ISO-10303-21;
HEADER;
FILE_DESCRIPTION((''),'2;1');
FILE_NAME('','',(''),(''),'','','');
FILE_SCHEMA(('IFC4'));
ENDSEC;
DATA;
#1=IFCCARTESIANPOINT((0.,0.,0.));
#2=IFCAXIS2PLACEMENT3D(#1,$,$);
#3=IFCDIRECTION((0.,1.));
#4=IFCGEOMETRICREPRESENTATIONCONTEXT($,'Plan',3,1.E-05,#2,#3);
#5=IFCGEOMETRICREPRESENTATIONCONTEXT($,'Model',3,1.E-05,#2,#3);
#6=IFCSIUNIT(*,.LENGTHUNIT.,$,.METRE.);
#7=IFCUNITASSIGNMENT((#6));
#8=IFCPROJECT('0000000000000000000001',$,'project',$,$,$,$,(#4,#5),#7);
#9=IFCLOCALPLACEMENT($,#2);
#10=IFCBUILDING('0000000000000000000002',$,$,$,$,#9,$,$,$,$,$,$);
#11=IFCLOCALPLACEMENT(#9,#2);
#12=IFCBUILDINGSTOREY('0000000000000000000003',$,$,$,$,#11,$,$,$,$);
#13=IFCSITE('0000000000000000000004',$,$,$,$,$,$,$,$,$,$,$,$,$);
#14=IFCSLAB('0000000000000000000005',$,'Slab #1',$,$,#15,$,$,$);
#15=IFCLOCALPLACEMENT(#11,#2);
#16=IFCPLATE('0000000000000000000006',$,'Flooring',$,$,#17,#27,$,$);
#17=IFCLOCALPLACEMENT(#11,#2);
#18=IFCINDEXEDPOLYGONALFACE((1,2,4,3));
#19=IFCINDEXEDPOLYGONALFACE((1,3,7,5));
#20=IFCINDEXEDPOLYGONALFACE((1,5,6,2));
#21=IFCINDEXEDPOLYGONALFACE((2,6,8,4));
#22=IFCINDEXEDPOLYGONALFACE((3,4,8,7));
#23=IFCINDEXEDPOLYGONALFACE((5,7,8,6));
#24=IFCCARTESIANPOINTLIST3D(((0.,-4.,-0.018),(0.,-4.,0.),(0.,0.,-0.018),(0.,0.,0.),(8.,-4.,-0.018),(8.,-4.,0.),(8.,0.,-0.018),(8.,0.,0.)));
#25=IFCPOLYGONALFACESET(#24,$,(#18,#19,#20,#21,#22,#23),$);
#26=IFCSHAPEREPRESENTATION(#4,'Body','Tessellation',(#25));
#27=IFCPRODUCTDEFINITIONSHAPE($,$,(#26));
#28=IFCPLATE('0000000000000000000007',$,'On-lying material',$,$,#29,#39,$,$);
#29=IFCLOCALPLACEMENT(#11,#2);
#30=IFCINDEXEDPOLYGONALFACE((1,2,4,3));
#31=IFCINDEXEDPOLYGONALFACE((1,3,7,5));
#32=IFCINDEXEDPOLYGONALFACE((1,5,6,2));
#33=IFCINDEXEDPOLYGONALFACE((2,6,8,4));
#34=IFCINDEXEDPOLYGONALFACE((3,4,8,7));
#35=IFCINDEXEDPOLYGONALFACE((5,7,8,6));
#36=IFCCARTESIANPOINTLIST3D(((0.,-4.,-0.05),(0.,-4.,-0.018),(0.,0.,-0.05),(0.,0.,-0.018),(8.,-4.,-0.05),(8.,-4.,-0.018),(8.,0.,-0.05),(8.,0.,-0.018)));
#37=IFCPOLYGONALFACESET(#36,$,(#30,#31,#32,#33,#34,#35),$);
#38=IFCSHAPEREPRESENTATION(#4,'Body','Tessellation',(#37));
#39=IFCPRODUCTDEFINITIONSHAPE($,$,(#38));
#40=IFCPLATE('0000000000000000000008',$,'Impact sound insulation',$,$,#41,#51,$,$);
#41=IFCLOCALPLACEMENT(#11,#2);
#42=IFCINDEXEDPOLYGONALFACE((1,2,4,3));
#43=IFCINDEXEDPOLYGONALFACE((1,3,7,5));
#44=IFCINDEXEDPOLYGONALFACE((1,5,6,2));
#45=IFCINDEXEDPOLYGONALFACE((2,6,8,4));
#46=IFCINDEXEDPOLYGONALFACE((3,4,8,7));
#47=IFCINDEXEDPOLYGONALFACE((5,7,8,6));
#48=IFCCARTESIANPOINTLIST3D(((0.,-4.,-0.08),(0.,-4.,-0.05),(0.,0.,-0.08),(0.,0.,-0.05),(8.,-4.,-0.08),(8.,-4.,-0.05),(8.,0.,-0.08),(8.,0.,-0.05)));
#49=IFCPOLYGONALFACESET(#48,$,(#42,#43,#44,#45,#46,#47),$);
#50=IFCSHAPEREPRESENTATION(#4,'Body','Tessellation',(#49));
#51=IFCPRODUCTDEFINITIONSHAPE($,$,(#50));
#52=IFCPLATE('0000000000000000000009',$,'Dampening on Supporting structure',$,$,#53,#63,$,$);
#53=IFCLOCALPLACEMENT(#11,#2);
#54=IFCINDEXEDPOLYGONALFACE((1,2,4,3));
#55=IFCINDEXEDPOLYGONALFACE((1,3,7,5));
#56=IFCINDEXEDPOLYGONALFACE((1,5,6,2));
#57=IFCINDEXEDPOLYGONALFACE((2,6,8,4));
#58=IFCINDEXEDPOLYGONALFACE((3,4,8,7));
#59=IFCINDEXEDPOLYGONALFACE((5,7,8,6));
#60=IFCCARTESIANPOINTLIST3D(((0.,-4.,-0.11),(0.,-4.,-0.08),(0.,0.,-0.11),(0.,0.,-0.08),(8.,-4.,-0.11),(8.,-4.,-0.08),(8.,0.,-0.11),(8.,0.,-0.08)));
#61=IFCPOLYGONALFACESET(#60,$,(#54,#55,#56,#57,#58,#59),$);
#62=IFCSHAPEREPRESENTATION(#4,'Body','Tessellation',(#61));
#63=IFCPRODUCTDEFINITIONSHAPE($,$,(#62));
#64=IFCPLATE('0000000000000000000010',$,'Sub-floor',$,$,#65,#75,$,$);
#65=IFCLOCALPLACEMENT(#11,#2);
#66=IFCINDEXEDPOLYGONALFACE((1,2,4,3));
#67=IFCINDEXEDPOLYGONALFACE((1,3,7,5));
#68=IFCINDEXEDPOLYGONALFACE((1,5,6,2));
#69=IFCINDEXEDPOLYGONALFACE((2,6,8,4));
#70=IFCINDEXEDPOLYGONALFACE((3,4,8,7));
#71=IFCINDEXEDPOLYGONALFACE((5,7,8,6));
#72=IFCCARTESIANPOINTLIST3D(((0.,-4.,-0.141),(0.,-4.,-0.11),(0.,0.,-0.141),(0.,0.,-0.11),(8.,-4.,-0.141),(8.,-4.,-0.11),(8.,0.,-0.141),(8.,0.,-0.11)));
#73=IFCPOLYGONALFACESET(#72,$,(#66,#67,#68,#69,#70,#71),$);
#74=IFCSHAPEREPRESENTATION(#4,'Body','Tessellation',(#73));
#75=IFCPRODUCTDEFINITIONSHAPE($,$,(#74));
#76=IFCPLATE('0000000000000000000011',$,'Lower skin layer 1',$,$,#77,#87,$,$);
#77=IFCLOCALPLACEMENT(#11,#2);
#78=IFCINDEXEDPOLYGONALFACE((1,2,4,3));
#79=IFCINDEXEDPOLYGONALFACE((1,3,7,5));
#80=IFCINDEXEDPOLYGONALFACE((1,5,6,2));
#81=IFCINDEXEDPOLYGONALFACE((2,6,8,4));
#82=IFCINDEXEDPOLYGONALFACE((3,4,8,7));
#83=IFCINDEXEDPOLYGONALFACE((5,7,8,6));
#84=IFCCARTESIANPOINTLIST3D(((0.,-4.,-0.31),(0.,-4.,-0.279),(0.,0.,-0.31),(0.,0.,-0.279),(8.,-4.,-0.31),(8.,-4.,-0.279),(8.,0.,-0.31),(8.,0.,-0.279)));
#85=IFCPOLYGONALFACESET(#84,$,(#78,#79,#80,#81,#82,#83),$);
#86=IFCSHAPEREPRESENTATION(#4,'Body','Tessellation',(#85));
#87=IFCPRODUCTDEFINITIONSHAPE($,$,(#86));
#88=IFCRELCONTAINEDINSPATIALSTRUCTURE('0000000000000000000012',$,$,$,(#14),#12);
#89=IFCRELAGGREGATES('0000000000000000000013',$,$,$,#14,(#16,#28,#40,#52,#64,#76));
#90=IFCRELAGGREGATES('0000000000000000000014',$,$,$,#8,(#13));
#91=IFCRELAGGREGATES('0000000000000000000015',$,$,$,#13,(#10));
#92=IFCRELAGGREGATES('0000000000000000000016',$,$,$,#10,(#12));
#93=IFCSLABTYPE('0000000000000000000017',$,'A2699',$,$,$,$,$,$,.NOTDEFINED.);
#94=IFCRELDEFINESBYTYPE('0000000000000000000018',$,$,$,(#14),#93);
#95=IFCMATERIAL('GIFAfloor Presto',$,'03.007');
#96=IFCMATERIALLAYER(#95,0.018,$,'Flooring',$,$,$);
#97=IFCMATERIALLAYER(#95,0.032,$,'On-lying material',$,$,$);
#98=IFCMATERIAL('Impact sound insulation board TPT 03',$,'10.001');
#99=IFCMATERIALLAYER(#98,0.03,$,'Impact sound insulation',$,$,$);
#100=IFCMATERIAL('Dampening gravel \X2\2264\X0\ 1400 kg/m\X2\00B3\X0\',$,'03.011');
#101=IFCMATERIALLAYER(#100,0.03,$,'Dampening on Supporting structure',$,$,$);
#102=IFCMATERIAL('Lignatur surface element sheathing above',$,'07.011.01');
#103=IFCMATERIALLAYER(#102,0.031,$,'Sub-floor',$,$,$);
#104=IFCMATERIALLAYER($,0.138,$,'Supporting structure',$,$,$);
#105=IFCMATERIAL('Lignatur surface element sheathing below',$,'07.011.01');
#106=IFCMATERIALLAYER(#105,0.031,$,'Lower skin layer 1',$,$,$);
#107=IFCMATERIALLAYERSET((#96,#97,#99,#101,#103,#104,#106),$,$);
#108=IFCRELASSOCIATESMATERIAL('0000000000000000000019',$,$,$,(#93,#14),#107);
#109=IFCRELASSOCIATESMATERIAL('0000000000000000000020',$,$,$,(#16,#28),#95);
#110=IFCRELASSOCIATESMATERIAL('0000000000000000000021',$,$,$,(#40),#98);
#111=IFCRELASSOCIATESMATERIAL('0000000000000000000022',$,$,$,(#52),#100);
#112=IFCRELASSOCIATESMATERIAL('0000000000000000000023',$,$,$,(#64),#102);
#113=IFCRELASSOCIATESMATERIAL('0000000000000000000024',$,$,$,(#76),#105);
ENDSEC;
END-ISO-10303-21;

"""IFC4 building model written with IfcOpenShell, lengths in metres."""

from ifc_helpers import new_model, si_unit, direction, frame, frame_2d, origin, origin_with_axes, place, context, project, spatial, rectangle, extrude, material, layer, layer_set, type_object, element, aggregate, save


model = new_model("IFC4")

# Units and contexts
plan_context = context("Plan", 3, precision=1e-05, world=origin(), true_north=direction((0.0, 1.0)))
model_context = context("Model", 3, precision=1e-05, world=origin(), true_north=direction((0.0, 1.0)))
ifc_project = project(units=[si_unit("LENGTHUNIT", "METRE")], contexts=[plan_context, model_context])

# Site, building, storey
site = spatial("IfcSite", under=ifc_project)
building_placement = place(None, origin())
building = spatial("IfcBuilding", under=site, at=building_placement)
storey_placement = place(building_placement, origin())
storey = spatial("IfcBuildingStorey", under=building, at=storey_placement)

# Slab, plates
ifc_material_1 = material(Name="GIFAfloor Presto", Category="03.007")
ifc_layer_1 = layer(ifc_material_1, 0.018, Name="Flooring")
ifc_layer_2 = layer(ifc_material_1, 0.032, Name="On-lying material")
ifc_material_2 = material(Name="Impact sound insulation board TPT 03", Category="10.001")
ifc_layer_3 = layer(ifc_material_2, 0.03, Name="Impact sound insulation")
ifc_material_3 = material(Name="Dampening gravel ≤ 1400 kg/m³", Category="03.011")
ifc_layer_4 = layer(ifc_material_3, 0.03, Name="Dampening on Supporting structure")
ifc_material_4 = material(Name="Lignatur surface element sheathing above", Category="07.011.01")
ifc_layer_5 = layer(ifc_material_4, 0.031, Name="Sub-floor")
ifc_layer_6 = layer(None, 0.138, Name="Supporting structure")
ifc_material_5 = material(Name="Lignatur surface element sheathing below", Category="07.011.01")
ifc_layer_7 = layer(ifc_material_5, 0.031, Name="Lower skin layer 1")
ifc_layer_set = layer_set([ifc_layer_1, ifc_layer_2, ifc_layer_3, ifc_layer_4, ifc_layer_5, ifc_layer_6, ifc_layer_7])
slab_type = type_object("IfcSlabType", Name="A2699", PredefinedType="NOTDEFINED", material=ifc_layer_set)
slab_placement = place(None, frame((0.0, 0.0, 0.0), z_axis=(0.0, 0.0, -1.0), x_axis=(1.0, 0.0, 0.0)))
slab = element("IfcSlab", 1, at=slab_placement, inside=storey, type_object=slab_type, material=ifc_layer_set, Name="Slab #1")
plate_1_placement = place(slab_placement, origin())
plate_1 = element("IfcPlate", 2, at=plate_1_placement, material=ifc_material_1, Name="Flooring", context=plan_context, shape_type="SweptSolid", body=[
    extrude(rectangle(XDim=8.0, YDim=4.0, at=frame_2d((4.0, 2.0), x_axis=(1.0, 0.0))), origin_with_axes(), (0.0, 0.0, 1.0), 0.018),
])
plate_2_placement = place(slab_placement, origin())
plate_2 = element("IfcPlate", 3, at=plate_2_placement, material=ifc_material_1, Name="On-lying material", context=plan_context, shape_type="SweptSolid", body=[
    extrude(rectangle(XDim=8.0, YDim=4.0, at=frame_2d((4.0, 2.0), x_axis=(1.0, 0.0))), frame((0.0, 0.0, 0.018), z_axis=(0.0, 0.0, 1.0), x_axis=(1.0, 0.0, 0.0)), (0.0, 0.0, 1.0), 0.032),
])
plate_3_placement = place(slab_placement, origin())
plate_3 = element("IfcPlate", 4, at=plate_3_placement, material=ifc_material_2, Name="Impact sound insulation", context=plan_context, shape_type="SweptSolid", body=[
    extrude(rectangle(XDim=8.0, YDim=4.0, at=frame_2d((4.0, 2.0), x_axis=(1.0, 0.0))), frame((0.0, 0.0, 0.05), z_axis=(0.0, 0.0, 1.0), x_axis=(1.0, 0.0, 0.0)), (0.0, 0.0, 1.0), 0.03),
])
plate_4_placement = place(slab_placement, origin())
plate_4 = element("IfcPlate", 5, at=plate_4_placement, material=ifc_material_3, Name="Dampening on Supporting structure", context=plan_context, shape_type="SweptSolid", body=[
    extrude(rectangle(XDim=8.0, YDim=4.0, at=frame_2d((4.0, 2.0), x_axis=(1.0, 0.0))), frame((0.0, 0.0, 0.08), z_axis=(0.0, 0.0, 1.0), x_axis=(1.0, 0.0, 0.0)), (0.0, 0.0, 1.0), 0.03),
])
plate_5_placement = place(slab_placement, origin())
plate_5 = element("IfcPlate", 6, at=plate_5_placement, material=ifc_material_4, Name="Sub-floor", context=plan_context, shape_type="SweptSolid", body=[
    extrude(rectangle(XDim=8.0, YDim=4.0, at=frame_2d((4.0, 2.0), x_axis=(1.0, 0.0))), frame((0.0, 0.0, 0.11), z_axis=(0.0, 0.0, 1.0), x_axis=(1.0, 0.0, 0.0)), (0.0, 0.0, 1.0), 0.031),
])
plate_6_placement = place(slab_placement, origin())
plate_6 = element("IfcPlate", 7, at=plate_6_placement, material=ifc_material_5, Name="Lower skin layer 1", context=plan_context, shape_type="SweptSolid", body=[
    extrude(rectangle(XDim=8.0, YDim=4.0, at=frame_2d((4.0, 2.0), x_axis=(1.0, 0.0))), frame((0.0, 0.0, 0.279), z_axis=(0.0, 0.0, 1.0), x_axis=(1.0, 0.0, 0.0)), (0.0, 0.0, 1.0), 0.031),
])
aggregate(slab, [plate_1, plate_2, plate_3, plate_4, plate_5, plate_6])

save(model, "model.ifc")
